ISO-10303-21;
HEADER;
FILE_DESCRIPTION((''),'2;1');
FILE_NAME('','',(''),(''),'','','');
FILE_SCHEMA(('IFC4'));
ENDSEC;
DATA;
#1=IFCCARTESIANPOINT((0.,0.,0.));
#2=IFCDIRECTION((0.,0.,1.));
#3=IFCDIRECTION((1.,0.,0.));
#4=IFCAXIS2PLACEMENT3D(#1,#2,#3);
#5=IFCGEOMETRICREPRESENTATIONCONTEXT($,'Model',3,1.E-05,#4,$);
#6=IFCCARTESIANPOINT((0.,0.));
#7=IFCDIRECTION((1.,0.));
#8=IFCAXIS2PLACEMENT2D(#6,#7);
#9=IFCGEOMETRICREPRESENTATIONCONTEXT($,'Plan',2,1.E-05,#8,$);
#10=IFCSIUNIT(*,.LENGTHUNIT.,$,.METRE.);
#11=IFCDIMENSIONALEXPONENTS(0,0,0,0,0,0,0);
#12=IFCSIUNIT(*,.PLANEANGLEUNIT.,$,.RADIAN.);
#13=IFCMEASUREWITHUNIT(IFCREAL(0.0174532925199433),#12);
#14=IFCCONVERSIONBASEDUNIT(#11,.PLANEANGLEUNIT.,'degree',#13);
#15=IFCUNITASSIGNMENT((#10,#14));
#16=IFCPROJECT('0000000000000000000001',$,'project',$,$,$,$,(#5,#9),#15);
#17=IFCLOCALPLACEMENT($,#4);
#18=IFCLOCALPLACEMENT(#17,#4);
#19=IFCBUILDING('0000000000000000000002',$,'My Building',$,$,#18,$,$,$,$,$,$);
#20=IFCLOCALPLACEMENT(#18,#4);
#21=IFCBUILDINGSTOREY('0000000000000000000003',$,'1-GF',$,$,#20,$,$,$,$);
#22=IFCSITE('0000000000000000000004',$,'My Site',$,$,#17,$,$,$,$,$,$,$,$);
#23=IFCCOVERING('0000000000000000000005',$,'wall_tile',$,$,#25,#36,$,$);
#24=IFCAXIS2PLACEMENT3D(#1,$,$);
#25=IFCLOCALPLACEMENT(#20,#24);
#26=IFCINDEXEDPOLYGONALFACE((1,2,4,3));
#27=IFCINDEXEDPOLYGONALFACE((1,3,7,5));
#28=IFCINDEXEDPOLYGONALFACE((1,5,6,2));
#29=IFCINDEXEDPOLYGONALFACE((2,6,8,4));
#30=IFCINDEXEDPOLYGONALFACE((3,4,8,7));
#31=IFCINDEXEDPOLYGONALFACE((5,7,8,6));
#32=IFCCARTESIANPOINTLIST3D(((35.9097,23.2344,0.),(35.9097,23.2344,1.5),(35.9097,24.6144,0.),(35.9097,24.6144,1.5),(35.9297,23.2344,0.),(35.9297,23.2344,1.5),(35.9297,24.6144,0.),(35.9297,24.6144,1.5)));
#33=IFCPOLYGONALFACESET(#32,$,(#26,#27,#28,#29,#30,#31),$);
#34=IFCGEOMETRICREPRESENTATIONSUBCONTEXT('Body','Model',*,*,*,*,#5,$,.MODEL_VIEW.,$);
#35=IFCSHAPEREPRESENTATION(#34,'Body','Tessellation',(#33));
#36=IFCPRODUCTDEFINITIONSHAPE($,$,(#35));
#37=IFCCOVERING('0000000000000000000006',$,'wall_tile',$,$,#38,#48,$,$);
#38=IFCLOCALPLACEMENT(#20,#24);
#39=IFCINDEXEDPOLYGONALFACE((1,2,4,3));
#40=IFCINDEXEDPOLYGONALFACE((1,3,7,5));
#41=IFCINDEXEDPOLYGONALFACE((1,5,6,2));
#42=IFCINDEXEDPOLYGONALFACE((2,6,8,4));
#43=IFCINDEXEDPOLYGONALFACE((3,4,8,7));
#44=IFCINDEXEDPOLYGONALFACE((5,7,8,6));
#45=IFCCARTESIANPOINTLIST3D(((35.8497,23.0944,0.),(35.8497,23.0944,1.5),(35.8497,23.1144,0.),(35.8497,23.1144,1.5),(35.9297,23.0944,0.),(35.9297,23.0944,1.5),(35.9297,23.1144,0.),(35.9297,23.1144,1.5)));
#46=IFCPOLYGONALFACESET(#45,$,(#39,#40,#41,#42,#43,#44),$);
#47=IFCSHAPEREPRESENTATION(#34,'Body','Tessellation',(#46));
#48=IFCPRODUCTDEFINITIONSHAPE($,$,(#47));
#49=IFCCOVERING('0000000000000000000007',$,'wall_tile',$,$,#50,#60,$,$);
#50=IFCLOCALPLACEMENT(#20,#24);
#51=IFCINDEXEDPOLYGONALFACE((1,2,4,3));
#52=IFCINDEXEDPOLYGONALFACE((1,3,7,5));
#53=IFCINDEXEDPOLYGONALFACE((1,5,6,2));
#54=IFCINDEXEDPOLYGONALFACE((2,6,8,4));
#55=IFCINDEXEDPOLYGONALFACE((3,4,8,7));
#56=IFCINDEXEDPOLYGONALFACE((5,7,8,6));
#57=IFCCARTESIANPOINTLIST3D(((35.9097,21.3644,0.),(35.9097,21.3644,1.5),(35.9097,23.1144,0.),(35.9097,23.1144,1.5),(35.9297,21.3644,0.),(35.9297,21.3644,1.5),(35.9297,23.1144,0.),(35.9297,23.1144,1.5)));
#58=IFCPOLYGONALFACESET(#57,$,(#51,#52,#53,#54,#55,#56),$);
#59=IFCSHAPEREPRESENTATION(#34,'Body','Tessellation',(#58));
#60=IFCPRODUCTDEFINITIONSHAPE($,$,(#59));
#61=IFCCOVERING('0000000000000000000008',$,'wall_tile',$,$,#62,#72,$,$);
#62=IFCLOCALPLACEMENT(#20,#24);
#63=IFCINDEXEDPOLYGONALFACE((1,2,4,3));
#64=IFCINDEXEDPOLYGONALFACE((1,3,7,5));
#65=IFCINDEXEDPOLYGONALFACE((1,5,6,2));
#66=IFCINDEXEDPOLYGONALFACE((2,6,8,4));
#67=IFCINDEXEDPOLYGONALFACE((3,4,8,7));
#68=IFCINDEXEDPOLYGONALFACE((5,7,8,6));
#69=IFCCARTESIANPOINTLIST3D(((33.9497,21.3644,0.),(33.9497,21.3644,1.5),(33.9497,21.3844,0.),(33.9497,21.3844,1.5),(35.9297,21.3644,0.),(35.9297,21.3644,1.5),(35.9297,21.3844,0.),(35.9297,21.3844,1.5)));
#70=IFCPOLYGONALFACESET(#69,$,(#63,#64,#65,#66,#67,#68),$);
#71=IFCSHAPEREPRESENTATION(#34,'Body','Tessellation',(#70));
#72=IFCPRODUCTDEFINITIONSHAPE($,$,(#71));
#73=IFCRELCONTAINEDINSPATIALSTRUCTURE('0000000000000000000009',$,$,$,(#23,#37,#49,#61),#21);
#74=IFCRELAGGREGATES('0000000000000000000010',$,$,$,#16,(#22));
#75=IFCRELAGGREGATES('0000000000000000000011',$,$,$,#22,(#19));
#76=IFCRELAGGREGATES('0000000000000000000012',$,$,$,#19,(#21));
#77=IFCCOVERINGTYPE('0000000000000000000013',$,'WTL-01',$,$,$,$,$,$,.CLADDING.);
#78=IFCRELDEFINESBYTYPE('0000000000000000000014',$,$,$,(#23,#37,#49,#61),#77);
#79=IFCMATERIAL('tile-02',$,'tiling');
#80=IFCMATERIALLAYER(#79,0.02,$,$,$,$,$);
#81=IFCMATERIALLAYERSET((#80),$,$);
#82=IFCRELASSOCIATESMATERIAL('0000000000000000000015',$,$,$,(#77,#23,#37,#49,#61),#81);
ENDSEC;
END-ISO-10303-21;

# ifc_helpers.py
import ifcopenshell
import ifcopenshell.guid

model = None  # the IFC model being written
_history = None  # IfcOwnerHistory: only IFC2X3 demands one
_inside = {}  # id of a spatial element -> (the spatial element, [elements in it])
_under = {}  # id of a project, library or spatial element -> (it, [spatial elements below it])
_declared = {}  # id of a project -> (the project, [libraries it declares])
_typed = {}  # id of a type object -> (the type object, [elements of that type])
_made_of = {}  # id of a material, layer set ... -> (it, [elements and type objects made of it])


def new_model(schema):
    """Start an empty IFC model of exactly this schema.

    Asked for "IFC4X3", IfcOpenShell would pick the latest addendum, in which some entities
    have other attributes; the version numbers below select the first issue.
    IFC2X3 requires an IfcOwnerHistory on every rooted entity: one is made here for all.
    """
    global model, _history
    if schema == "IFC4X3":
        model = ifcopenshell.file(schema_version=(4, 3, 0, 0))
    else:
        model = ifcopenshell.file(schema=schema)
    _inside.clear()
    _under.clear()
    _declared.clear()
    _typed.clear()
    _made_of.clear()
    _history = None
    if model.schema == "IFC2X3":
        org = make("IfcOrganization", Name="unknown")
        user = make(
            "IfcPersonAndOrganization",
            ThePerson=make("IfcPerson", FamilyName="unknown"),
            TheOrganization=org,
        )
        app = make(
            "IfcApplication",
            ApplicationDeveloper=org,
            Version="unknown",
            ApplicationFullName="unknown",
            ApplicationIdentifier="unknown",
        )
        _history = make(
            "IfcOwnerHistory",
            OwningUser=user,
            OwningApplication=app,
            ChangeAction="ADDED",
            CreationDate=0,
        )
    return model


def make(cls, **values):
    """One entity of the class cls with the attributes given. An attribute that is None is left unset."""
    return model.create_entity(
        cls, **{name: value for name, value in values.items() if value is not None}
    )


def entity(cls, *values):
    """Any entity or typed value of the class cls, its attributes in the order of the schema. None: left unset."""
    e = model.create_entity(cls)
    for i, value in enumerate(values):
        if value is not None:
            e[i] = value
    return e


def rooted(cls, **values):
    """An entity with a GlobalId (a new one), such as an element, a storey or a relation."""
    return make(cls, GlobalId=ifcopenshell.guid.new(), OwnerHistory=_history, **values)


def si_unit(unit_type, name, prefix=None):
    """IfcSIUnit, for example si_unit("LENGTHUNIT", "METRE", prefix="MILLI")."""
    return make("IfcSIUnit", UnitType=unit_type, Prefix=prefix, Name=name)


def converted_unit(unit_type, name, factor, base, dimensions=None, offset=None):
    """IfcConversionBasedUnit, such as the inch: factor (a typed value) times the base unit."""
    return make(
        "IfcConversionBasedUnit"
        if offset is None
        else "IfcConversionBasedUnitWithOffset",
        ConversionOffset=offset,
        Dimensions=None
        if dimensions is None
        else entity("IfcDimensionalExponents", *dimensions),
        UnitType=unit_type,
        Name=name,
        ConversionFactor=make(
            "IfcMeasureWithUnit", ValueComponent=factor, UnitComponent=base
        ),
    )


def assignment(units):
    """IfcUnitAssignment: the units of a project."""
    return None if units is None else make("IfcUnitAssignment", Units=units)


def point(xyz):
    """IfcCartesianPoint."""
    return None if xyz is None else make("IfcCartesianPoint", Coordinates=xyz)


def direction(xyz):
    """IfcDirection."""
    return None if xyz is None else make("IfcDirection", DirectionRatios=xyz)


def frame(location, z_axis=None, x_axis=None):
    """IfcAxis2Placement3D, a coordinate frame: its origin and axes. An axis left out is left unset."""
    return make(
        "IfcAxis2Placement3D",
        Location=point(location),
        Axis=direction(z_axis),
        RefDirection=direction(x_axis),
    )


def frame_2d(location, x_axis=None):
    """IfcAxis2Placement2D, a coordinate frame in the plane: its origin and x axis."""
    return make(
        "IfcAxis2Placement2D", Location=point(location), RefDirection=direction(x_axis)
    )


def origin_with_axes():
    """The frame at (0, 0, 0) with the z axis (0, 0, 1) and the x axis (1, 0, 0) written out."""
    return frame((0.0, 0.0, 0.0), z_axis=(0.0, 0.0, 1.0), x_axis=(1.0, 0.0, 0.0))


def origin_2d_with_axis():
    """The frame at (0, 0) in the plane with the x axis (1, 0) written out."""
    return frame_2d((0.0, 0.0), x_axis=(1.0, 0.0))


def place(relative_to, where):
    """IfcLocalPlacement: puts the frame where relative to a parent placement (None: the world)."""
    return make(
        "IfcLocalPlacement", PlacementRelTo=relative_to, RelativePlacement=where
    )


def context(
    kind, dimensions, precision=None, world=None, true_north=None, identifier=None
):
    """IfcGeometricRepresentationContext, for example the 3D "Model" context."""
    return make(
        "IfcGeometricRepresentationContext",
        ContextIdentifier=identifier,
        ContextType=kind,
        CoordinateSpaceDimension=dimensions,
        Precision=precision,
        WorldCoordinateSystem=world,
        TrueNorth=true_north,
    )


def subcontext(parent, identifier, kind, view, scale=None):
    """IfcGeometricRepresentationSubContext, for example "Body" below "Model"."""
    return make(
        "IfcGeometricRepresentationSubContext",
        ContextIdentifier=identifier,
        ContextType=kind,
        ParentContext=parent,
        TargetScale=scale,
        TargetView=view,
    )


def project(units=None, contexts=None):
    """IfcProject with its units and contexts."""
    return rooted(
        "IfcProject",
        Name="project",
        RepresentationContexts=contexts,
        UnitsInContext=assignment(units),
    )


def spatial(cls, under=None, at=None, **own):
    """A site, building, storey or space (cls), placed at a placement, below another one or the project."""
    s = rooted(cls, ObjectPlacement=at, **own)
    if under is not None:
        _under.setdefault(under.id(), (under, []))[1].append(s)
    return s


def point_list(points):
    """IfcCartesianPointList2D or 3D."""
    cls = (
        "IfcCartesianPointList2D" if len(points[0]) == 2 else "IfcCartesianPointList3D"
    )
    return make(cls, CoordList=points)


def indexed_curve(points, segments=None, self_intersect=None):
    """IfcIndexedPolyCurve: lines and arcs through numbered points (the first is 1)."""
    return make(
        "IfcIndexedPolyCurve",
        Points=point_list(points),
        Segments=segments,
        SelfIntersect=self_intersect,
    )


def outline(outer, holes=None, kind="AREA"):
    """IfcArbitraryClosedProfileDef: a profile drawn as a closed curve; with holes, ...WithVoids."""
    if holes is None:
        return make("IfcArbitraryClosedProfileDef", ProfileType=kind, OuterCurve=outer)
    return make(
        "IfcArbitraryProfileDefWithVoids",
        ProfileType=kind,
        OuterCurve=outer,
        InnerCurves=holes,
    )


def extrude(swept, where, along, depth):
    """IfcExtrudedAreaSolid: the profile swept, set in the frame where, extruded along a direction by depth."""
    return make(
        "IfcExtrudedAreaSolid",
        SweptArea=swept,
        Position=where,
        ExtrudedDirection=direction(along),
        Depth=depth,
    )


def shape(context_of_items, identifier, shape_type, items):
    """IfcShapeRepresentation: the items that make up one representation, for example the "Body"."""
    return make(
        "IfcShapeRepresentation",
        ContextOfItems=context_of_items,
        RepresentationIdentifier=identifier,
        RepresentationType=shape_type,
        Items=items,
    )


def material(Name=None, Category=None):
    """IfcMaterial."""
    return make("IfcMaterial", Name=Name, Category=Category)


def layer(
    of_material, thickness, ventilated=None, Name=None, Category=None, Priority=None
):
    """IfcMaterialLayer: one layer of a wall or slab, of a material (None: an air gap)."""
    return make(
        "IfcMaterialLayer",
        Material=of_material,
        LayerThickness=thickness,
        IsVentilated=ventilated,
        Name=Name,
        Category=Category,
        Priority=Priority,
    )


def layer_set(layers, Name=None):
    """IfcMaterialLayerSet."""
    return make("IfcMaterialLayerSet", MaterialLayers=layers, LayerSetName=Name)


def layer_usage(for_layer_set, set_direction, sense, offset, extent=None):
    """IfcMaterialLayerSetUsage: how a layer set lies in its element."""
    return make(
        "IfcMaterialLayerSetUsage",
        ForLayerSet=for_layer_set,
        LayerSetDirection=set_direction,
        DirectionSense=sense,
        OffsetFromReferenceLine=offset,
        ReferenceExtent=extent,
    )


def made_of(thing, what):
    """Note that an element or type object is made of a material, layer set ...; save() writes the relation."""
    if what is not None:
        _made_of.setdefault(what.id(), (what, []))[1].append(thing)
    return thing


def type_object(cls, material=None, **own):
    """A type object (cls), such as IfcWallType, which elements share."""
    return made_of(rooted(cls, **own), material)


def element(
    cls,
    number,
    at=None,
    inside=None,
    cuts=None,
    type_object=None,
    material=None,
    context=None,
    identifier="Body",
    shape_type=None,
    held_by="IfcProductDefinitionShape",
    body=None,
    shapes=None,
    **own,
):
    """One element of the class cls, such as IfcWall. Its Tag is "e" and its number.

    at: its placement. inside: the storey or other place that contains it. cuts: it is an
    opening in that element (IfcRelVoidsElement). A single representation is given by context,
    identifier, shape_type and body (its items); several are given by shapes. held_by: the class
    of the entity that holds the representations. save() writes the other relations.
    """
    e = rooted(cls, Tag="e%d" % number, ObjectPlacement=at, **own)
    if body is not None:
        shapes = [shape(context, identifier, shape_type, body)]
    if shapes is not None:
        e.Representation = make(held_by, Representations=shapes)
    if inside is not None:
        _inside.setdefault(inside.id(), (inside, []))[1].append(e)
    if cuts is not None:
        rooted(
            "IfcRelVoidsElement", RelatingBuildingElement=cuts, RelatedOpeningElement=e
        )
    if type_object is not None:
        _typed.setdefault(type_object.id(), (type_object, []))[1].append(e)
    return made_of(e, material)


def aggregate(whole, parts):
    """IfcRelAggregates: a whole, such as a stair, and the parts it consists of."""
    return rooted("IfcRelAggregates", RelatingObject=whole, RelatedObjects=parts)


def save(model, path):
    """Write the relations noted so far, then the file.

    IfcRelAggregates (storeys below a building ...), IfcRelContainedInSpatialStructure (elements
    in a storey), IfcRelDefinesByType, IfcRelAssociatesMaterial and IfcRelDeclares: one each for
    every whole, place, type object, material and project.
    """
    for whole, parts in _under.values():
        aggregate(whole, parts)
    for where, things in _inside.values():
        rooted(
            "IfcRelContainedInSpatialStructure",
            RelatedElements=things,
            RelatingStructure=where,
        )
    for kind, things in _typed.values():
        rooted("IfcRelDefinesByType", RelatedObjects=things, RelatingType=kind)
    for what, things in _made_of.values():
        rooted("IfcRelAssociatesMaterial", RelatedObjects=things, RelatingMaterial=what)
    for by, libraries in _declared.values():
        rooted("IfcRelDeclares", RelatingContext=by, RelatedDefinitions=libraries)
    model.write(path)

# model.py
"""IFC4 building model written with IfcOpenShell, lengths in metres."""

from ifc_helpers import new_model, entity, si_unit, converted_unit, frame, origin_with_axes, origin_2d_with_axis, place, context, subcontext, project, spatial, indexed_curve, outline, extrude, material, layer, layer_set, layer_usage, type_object, element, save


model = new_model("IFC4")

# Units and contexts
model_context = context("Model", 3, precision=1e-05, world=origin_with_axes())
plan_context = context("Plan", 2, precision=1e-05, world=origin_2d_with_axis())
body_context_1 = subcontext(model_context, "Body", "Model", "MODEL_VIEW")
ifc_project = project(units=[si_unit("LENGTHUNIT", "METRE"), converted_unit("PLANEANGLEUNIT", "degree", entity("IfcReal", 0.0174532925199433), si_unit("PLANEANGLEUNIT", "RADIAN"), dimensions=[0, 0, 0, 0, 0, 0, 0])], contexts=[model_context, plan_context])

# Site, building, storey
site_placement = place(None, origin_with_axes())
site = spatial("IfcSite", under=ifc_project, at=site_placement, Name="My Site")
building_placement = place(site_placement, origin_with_axes())
building = spatial("IfcBuilding", under=site, at=building_placement, Name="My Building")
storey_placement = place(building_placement, origin_with_axes())
storey = spatial("IfcBuildingStorey", under=building, at=storey_placement, Name="1-GF")

# Coverings
ifc_material_1 = material(Name="tile-02", Category="tiling")
ifc_layer_1 = layer(ifc_material_1, 0.02)
ifc_layer_set_1 = layer_set([ifc_layer_1])
covering_type = type_object("IfcCoveringType", Name="WTL-01", PredefinedType="CLADDING", material=ifc_layer_set_1)
ifc_layer_usage_1 = layer_usage(ifc_layer_set_1, "AXIS2", "POSITIVE", 0.0)
covering_1_placement = place(storey_placement, frame((35.9297, 23.2344, 0.0), z_axis=(0.0, 0.0, 1.0), x_axis=(0.000001, 1.0, 0.0)))
element("IfcCovering", 1, at=covering_1_placement, inside=storey, type_object=covering_type, material=ifc_layer_usage_1, Name="wall_tile", context=body_context_1, shape_type="SweptSolid", body=[
    extrude(outline(indexed_curve([(0.0, 0.0), (0.0, 0.02), (1.38, 0.02), (1.38, 0.0), (0.0, 0.0)], self_intersect=False)), origin_with_axes(), (0.0, 0.0, 1.0), 1.5),
])
ifc_layer_usage_2 = layer_usage(ifc_layer_set_1, "AXIS2", "POSITIVE", 0.0)
covering_2_placement = place(storey_placement, frame((35.9297, 23.1144, 0.0), z_axis=(0.0, 0.0, 1.0), x_axis=(-1.0, 0.000001, 0.0)))
element("IfcCovering", 2, at=covering_2_placement, inside=storey, type_object=covering_type, material=ifc_layer_usage_2, Name="wall_tile", context=body_context_1, shape_type="SweptSolid", body=[
    extrude(outline(indexed_curve([(0.0, 0.0), (0.0, 0.02), (0.08, 0.02), (0.08, 0.0), (0.0, 0.0)], self_intersect=False)), origin_with_axes(), (0.0, 0.0, 1.0), 1.5),
])
ifc_layer_usage_3 = layer_usage(ifc_layer_set_1, "AXIS2", "POSITIVE", 0.0)
covering_3_placement = place(storey_placement, frame((35.9297, 21.3644, 0.0), z_axis=(0.0, 0.0, 1.0), x_axis=(0.000001, 1.0, 0.0)))
element("IfcCovering", 3, at=covering_3_placement, inside=storey, type_object=covering_type, material=ifc_layer_usage_3, Name="wall_tile", context=body_context_1, shape_type="SweptSolid", body=[
    extrude(outline(indexed_curve([(0.0, 0.0), (0.0, 0.02), (1.75, 0.02), (1.75, 0.0), (0.0, 0.0)], self_intersect=False)), origin_with_axes(), (0.0, 0.0, 1.0), 1.5),
])
ifc_layer_usage_4 = layer_usage(ifc_layer_set_1, "AXIS2", "POSITIVE", 0.0)
covering_4_placement = place(storey_placement, frame((35.9297, 21.3844, 0.0), z_axis=(0.0, 0.0, 1.0), x_axis=(-1.0, 0.000001, 0.0)))
element("IfcCovering", 4, at=covering_4_placement, inside=storey, type_object=covering_type, material=ifc_layer_usage_4, Name="wall_tile", context=body_context_1, shape_type="SweptSolid", body=[
    extrude(outline(indexed_curve([(0.0, 0.0), (0.0, 0.02), (1.98, 0.02), (1.98, 0.0), (0.0, 0.0)], self_intersect=False)), origin_with_axes(), (0.0, 0.0, 1.0), 1.5),
])

save(model, "model.ifc")
